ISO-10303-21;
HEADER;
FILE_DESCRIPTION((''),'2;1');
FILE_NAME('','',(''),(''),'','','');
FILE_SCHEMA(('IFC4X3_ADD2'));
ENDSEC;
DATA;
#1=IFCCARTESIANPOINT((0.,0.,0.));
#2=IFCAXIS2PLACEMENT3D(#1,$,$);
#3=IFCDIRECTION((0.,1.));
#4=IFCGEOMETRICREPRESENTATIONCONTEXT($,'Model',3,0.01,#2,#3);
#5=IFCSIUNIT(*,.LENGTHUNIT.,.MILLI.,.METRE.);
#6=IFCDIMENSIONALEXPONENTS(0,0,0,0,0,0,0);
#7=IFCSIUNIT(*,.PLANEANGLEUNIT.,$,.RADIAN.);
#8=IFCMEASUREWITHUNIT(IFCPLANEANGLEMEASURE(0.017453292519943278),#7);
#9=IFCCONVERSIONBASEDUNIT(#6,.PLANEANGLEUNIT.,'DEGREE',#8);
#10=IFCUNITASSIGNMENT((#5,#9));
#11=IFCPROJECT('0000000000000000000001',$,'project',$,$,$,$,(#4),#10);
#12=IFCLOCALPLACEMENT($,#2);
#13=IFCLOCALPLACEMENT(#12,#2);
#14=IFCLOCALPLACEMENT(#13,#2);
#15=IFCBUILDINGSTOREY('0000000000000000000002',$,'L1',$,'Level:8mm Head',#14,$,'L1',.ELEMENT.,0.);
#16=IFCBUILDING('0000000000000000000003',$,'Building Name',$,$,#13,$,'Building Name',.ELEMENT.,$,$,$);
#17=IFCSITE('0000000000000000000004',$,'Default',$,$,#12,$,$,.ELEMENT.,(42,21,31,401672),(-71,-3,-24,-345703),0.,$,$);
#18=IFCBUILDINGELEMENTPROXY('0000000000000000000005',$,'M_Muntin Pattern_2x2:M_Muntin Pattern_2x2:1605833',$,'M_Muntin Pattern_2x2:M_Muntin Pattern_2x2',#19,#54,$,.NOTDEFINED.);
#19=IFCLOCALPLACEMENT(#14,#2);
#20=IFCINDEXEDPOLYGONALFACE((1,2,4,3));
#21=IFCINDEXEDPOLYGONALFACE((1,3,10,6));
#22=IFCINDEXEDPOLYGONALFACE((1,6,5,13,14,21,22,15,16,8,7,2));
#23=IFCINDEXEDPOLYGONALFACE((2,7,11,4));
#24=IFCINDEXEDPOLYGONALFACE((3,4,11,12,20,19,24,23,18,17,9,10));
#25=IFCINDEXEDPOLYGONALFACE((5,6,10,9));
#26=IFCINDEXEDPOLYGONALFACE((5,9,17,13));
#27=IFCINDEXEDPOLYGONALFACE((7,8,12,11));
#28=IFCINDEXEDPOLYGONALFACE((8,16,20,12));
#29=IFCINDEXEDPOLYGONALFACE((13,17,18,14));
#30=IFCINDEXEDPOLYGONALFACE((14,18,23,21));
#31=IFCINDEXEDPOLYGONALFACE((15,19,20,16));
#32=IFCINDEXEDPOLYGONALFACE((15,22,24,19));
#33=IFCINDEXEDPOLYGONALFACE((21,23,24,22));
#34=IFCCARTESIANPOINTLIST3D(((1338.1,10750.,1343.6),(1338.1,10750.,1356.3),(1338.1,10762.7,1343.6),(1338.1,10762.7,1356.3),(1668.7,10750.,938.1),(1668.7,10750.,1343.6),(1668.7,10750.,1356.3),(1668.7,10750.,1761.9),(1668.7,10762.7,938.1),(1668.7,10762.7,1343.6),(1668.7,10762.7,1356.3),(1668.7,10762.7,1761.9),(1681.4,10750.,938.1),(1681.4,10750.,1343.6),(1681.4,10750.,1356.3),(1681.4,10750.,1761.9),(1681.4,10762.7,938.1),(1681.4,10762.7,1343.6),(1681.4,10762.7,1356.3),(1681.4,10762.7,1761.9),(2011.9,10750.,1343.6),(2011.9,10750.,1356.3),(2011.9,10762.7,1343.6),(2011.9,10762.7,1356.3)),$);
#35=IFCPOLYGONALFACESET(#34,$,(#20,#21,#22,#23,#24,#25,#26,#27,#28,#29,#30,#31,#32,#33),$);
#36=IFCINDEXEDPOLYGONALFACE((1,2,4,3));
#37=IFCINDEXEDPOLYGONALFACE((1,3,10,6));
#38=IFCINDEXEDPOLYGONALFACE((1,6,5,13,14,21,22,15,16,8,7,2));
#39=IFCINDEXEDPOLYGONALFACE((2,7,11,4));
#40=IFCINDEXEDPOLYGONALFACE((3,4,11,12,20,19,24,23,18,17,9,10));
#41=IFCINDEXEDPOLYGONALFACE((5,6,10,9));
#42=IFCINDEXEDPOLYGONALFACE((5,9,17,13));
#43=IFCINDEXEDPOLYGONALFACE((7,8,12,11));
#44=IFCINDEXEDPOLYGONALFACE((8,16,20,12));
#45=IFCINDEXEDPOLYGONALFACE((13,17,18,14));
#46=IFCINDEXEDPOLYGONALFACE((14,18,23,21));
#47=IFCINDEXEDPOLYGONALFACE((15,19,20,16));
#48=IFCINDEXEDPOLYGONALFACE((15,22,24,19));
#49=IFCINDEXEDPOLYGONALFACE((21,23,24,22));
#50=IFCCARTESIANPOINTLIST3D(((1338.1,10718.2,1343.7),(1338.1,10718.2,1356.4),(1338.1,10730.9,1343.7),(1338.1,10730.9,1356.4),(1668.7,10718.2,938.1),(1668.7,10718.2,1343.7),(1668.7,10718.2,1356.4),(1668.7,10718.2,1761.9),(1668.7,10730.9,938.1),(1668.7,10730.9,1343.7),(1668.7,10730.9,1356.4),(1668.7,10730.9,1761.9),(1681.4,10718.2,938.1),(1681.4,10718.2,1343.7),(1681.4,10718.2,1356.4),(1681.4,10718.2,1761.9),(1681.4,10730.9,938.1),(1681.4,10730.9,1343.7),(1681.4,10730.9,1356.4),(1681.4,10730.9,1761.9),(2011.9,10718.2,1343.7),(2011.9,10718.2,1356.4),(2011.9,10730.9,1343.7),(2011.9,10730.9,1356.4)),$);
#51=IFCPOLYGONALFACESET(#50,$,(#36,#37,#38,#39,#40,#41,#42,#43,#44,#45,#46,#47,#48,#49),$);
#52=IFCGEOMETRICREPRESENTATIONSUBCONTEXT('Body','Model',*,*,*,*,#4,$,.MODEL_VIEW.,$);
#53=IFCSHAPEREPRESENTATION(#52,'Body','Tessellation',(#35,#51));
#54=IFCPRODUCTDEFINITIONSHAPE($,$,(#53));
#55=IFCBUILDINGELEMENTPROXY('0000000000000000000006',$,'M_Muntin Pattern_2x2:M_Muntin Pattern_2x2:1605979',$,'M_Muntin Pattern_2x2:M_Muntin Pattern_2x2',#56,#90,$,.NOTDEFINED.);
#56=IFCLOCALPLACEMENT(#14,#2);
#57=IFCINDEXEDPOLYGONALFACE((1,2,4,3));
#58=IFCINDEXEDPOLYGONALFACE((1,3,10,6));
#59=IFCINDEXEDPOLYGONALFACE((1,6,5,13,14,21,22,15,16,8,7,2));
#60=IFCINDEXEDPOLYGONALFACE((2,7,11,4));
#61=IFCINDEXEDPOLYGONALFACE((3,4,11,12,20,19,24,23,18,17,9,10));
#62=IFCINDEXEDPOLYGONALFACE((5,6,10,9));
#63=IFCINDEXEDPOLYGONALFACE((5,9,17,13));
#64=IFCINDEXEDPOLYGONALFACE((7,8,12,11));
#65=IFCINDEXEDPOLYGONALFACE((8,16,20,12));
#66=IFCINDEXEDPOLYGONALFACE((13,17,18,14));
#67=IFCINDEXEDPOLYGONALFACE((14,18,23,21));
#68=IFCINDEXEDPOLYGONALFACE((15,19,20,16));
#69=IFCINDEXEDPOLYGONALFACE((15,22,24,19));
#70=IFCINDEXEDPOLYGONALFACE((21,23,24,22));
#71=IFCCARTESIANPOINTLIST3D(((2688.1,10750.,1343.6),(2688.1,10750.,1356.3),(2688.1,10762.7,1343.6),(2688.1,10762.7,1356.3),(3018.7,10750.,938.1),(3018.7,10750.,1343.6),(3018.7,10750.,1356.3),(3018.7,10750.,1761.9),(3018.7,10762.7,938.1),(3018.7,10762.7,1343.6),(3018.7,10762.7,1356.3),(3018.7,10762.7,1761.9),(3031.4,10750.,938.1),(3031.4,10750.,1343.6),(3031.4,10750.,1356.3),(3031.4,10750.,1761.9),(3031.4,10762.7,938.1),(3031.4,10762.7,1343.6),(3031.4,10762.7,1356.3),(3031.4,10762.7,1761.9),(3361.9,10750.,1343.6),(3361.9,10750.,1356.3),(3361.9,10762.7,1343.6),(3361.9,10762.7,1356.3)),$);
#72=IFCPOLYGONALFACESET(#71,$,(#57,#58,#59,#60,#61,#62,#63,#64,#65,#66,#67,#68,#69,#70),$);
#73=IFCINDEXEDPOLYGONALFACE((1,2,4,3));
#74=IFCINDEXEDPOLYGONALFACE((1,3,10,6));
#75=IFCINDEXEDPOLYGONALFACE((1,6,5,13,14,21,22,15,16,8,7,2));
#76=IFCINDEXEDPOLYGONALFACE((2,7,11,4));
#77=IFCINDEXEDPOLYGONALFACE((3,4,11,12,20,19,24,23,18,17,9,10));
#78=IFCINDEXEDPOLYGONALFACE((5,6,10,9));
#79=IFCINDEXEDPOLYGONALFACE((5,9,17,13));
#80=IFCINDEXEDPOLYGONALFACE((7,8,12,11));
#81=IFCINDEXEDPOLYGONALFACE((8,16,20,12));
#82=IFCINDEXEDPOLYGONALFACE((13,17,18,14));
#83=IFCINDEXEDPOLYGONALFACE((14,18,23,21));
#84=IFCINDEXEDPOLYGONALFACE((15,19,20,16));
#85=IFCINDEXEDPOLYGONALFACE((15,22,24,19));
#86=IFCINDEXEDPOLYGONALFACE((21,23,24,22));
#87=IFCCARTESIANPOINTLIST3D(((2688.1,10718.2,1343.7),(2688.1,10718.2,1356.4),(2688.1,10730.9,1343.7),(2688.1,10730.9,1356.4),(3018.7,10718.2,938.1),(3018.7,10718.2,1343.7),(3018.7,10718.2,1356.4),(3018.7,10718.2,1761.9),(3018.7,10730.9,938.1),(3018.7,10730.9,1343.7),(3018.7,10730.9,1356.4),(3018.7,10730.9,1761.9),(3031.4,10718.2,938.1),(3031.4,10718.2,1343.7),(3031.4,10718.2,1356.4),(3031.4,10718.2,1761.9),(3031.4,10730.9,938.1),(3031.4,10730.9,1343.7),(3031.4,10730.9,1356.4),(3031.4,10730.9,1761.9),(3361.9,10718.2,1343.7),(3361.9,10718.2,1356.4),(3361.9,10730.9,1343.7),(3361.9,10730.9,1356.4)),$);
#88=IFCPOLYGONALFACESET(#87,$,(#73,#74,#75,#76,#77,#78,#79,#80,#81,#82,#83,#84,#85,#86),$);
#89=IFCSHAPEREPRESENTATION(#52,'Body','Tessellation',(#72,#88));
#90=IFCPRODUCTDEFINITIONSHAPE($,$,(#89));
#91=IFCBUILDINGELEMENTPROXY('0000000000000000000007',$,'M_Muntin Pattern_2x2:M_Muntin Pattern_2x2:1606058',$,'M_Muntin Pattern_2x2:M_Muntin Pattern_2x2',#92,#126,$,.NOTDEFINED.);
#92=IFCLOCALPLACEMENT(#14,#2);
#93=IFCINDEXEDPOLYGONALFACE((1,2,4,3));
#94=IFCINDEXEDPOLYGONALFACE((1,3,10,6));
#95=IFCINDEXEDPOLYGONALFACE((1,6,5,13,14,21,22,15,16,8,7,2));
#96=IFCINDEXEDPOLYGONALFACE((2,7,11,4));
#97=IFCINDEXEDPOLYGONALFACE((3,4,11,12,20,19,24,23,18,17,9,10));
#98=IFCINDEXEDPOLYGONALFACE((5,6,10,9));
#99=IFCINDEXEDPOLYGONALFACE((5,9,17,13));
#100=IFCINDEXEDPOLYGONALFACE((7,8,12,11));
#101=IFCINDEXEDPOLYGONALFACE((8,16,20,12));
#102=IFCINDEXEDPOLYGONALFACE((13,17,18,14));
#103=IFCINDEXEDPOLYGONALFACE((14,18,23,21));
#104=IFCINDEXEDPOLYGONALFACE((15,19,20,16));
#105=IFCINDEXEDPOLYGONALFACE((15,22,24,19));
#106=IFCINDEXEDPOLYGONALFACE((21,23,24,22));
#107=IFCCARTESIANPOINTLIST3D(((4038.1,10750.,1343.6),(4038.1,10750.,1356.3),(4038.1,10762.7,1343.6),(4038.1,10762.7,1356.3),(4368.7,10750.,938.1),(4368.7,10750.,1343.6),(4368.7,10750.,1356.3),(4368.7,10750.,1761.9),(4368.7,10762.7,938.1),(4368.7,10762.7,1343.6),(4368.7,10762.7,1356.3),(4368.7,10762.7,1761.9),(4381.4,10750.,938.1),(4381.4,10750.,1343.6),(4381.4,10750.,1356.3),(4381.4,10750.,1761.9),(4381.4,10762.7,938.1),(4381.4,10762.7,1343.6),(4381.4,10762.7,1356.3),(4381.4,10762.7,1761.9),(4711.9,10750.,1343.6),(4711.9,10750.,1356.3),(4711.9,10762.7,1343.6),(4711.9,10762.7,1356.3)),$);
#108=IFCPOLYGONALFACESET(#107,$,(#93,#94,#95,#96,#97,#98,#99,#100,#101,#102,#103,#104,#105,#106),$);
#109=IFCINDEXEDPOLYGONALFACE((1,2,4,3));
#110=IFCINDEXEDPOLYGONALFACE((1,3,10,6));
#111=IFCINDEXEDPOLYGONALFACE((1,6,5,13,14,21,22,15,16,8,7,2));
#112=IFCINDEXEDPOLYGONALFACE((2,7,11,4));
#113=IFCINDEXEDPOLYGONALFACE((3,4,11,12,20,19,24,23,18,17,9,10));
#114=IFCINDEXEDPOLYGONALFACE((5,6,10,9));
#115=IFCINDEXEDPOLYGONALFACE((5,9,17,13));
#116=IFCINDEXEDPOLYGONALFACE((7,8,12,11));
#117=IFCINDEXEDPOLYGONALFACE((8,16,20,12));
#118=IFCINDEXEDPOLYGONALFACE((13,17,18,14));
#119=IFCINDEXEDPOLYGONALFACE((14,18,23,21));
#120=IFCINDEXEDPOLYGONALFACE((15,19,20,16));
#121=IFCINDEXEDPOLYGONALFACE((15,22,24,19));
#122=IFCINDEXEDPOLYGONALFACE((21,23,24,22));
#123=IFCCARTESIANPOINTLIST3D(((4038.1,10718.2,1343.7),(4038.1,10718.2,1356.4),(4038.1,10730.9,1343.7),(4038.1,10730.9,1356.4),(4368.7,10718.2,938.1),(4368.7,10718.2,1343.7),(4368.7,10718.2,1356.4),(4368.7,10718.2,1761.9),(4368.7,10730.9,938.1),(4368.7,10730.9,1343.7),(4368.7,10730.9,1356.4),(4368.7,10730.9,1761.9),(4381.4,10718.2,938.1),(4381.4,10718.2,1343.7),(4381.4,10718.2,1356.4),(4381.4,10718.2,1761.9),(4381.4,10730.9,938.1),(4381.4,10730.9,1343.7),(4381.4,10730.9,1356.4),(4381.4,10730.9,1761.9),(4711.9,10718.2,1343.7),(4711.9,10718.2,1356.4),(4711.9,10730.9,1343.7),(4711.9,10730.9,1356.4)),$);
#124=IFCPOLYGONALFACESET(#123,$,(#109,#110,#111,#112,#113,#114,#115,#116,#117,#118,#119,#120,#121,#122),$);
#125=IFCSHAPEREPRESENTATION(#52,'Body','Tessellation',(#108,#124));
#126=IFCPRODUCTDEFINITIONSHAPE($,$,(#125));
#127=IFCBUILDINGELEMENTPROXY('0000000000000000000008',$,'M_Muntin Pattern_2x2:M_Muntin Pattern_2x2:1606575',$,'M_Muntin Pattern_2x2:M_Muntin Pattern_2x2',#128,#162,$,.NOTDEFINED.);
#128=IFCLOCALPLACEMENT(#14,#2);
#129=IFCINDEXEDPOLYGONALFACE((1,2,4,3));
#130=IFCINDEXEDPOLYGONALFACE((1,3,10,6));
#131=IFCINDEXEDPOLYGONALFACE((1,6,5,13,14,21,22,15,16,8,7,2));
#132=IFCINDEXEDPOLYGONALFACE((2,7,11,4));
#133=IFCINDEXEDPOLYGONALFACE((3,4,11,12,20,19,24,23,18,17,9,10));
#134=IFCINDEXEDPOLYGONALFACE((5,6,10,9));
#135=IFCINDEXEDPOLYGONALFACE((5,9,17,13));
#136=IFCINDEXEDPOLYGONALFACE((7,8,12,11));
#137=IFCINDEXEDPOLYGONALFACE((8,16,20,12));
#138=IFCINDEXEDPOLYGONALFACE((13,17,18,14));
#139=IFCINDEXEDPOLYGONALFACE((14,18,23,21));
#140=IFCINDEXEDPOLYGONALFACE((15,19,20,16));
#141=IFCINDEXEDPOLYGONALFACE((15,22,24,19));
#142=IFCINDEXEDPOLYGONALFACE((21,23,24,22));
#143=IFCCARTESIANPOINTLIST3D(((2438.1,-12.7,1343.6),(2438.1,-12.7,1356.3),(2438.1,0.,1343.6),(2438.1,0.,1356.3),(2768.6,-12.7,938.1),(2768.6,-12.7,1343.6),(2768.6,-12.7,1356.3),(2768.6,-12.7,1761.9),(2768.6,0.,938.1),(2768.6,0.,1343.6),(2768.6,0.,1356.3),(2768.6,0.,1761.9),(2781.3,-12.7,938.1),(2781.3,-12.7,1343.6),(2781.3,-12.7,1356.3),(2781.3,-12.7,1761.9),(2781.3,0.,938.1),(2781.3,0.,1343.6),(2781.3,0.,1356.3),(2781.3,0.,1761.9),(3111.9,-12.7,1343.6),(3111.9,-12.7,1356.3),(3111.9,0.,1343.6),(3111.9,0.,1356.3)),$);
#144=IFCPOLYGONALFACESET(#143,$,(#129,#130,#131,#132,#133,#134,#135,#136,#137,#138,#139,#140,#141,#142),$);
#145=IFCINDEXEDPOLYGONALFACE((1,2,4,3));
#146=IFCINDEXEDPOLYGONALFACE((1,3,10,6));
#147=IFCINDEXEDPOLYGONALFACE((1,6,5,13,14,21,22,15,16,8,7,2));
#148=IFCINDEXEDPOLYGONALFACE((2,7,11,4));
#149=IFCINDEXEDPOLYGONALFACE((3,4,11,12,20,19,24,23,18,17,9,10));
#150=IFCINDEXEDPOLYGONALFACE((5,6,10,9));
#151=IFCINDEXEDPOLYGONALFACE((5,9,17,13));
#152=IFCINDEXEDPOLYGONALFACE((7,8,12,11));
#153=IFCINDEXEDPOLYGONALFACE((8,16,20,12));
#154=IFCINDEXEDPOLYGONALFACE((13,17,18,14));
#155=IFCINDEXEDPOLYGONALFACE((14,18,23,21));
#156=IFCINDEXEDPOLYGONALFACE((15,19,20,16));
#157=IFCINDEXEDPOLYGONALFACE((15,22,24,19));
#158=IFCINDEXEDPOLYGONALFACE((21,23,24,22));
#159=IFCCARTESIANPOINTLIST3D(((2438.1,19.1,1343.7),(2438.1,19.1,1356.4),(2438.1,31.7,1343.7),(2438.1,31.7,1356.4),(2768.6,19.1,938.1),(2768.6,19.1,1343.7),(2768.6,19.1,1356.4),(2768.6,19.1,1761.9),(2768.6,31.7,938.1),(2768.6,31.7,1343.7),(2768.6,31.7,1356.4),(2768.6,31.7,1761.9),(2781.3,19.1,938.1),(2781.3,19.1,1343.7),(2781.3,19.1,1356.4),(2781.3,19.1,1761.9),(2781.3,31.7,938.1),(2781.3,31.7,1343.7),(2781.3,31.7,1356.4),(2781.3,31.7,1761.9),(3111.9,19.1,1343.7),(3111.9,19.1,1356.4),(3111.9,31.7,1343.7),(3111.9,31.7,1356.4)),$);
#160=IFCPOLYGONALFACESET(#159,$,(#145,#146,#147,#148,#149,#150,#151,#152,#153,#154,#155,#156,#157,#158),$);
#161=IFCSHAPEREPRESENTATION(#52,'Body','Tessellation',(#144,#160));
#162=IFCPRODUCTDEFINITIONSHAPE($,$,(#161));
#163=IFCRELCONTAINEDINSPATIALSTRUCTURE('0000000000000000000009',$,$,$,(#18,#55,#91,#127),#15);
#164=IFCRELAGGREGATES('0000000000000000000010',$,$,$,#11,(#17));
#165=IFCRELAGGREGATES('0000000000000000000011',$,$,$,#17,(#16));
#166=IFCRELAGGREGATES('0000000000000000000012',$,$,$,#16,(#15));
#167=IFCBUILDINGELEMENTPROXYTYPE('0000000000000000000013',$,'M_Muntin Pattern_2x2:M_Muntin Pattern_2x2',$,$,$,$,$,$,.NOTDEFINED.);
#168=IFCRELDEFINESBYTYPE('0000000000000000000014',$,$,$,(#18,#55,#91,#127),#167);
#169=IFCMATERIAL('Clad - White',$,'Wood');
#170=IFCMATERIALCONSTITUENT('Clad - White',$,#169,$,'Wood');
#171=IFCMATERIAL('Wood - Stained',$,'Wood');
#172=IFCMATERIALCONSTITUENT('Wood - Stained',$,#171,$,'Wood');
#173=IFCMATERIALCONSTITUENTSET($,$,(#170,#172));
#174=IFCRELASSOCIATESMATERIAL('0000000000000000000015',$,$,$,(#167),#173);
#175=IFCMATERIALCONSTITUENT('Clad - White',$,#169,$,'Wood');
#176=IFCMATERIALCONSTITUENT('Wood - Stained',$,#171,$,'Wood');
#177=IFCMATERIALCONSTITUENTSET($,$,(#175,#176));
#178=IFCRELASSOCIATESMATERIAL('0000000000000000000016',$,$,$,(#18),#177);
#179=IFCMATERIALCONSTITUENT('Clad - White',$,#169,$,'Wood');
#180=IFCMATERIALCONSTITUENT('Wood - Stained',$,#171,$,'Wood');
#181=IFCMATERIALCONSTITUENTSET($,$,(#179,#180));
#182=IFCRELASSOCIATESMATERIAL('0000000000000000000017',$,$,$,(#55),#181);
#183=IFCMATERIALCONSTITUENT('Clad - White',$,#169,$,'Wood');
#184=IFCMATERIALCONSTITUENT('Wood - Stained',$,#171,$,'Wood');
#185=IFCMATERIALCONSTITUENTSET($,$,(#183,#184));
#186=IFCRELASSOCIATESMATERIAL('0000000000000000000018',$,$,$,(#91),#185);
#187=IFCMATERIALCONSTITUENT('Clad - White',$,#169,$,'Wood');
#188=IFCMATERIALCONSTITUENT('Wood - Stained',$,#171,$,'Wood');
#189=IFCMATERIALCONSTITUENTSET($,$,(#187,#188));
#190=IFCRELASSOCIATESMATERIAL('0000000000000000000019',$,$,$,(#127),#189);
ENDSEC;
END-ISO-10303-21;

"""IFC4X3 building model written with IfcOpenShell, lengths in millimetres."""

from ifc_helpers import new_model, entity, si_unit, converted_unit, direction, frame, origin, place, context, subcontext, project, spatial, polyline, outline, extrude, source, transform, mapped, material, constituent, constituent_set, type_object, type_shapes, element, save


model = new_model("IFC4X3")

# Units and contexts
model_context = context("Model", 3, precision=0.01, world=origin(), true_north=direction((0.0, 1.0)))
body_context = subcontext(model_context, "Body", "Model", "MODEL_VIEW")
ifc_project = project(units=[si_unit("LENGTHUNIT", "METRE", prefix="MILLI"), converted_unit("PLANEANGLEUNIT", "DEGREE", entity("IfcPlaneAngleMeasure", 0.017453292519943278), si_unit("PLANEANGLEUNIT", "RADIAN"), dimensions=[0, 0, 0, 0, 0, 0, 0])], contexts=[model_context])

# Site, building, storey
site_placement = place(None, origin())
site = spatial("IfcSite", under=ifc_project, at=site_placement, Name="Default", CompositionType="ELEMENT", RefLatitude=(42, 21, 31, 401672), RefLongitude=(-71, -3, -24, -345703), RefElevation=0.0)
building_placement = place(site_placement, origin())
building = spatial("IfcBuilding", under=site, at=building_placement, Name="Building Name", LongName="Building Name", CompositionType="ELEMENT")
storey_placement = place(building_placement, origin())
storey = spatial("IfcBuildingStorey", under=building, at=storey_placement, Name="L1", ObjectType="Level:8mm Head", LongName="L1", CompositionType="ELEMENT", Elevation=0.0)

# Building element proxies
ifc_material_1 = material(Name="Clad - White", Category="Wood")
ifc_constituent_1 = constituent(ifc_material_1, Name="Clad - White", Category="Wood")
ifc_material_2 = material(Name="Wood - Stained", Category="Wood")
ifc_constituent_2 = constituent(ifc_material_2, Name="Wood - Stained", Category="Wood")
ifc_constituent_set_1 = constituent_set(constituents=[ifc_constituent_1, ifc_constituent_2])
ifc_constituent_3 = constituent(ifc_material_1, Name="Clad - White", Category="Wood")
ifc_constituent_4 = constituent(ifc_material_2, Name="Wood - Stained", Category="Wood")
ifc_constituent_set_2 = constituent_set(constituents=[ifc_constituent_3, ifc_constituent_4])
building_element_proxy_type_1 = type_object("IfcBuildingElementProxyType", Name="M_Muntin Pattern_2x2:M_Muntin Pattern_2x2", PredefinedType="NOTDEFINED", material=ifc_constituent_set_2)
shared_shape_1 = source(origin(), body_context, "Body", "SweptSolid", [
    extrude(outline(polyline([(6.4, -6.4), (411.9, -6.4), (411.9, 6.3), (6.4, 6.3), (6.4, 336.9), (-6.3, 336.9), (-6.3, 6.3), (-411.9, 6.3), (-411.9, -6.4), (-6.3, -6.4), (-6.3, -336.9), (6.4, -336.9), (6.4, -6.4)])), frame((0.0, -22.2, 411.9), z_axis=(0.0, 1.0, 0.0), x_axis=(0.0, 0.0, 1.0)), (0.0, 0.0, 1.0), 12.7),
    extrude(outline(polyline([(6.4, -6.4), (411.9, -6.4), (411.9, 6.3), (6.4, 6.3), (6.4, 336.9), (-6.3, 336.9), (-6.3, 6.3), (-411.9, 6.3), (-411.9, -6.4), (-6.3, -6.4), (-6.3, -336.9), (6.4, -336.9), (6.4, -6.4)])), frame((0.0, 9.5, 411.9), z_axis=(0.0, 1.0, 0.0), x_axis=(0.0, 0.0, 1.0)), (0.0, 0.0, 1.0), 12.7),
])
type_shapes(building_element_proxy_type_1, [shared_shape_1])
proxy_1_placement = place(storey_placement, frame((1675.0, 10740.5, 938.1), z_axis=(0.0, 0.0, 1.0), x_axis=(-1.0, 0.0, 0.0)))
element("IfcBuildingElementProxy", 1, at=proxy_1_placement, inside=storey, type_object=building_element_proxy_type_1, material=ifc_constituent_set_1, Name="M_Muntin Pattern_2x2:M_Muntin Pattern_2x2:1605833", ObjectType="M_Muntin Pattern_2x2:M_Muntin Pattern_2x2", PredefinedType="NOTDEFINED", context=body_context, shape_type="MappedRepresentation", body=[
    mapped(shared_shape_1, transform((0.0, 0.0, 0.0), scale=1.0)),
])
ifc_constituent_5 = constituent(ifc_material_1, Name="Clad - White", Category="Wood")
ifc_constituent_6 = constituent(ifc_material_2, Name="Wood - Stained", Category="Wood")
ifc_constituent_set_3 = constituent_set(constituents=[ifc_constituent_5, ifc_constituent_6])
proxy_2_placement = place(storey_placement, frame((3025.0, 10740.5, 938.1), z_axis=(0.0, 0.0, 1.0), x_axis=(-1.0, 0.0, 0.0)))
element("IfcBuildingElementProxy", 2, at=proxy_2_placement, inside=storey, type_object=building_element_proxy_type_1, material=ifc_constituent_set_3, Name="M_Muntin Pattern_2x2:M_Muntin Pattern_2x2:1605979", ObjectType="M_Muntin Pattern_2x2:M_Muntin Pattern_2x2", PredefinedType="NOTDEFINED", context=body_context, shape_type="MappedRepresentation", body=[
    mapped(shared_shape_1, transform((0.0, 0.0, 0.0), scale=1.0)),
])
ifc_constituent_7 = constituent(ifc_material_1, Name="Clad - White", Category="Wood")
ifc_constituent_8 = constituent(ifc_material_2, Name="Wood - Stained", Category="Wood")
ifc_constituent_set_4 = constituent_set(constituents=[ifc_constituent_7, ifc_constituent_8])
proxy_3_placement = place(storey_placement, frame((4375.0, 10740.5, 938.1), z_axis=(0.0, 0.0, 1.0), x_axis=(-1.0, 0.0, 0.0)))
element("IfcBuildingElementProxy", 3, at=proxy_3_placement, inside=storey, type_object=building_element_proxy_type_1, material=ifc_constituent_set_4, Name="M_Muntin Pattern_2x2:M_Muntin Pattern_2x2:1606058", ObjectType="M_Muntin Pattern_2x2:M_Muntin Pattern_2x2", PredefinedType="NOTDEFINED", context=body_context, shape_type="MappedRepresentation", body=[
    mapped(shared_shape_1, transform((0.0, 0.0, 0.0), scale=1.0)),
])
ifc_constituent_9 = constituent(ifc_material_1, Name="Clad - White", Category="Wood")
ifc_constituent_10 = constituent(ifc_material_2, Name="Wood - Stained", Category="Wood")
ifc_constituent_set_5 = constituent_set(constituents=[ifc_constituent_9, ifc_constituent_10])
proxy_4_placement = place(storey_placement, frame((2775.0, 9.5, 938.1)))
element("IfcBuildingElementProxy", 4, at=proxy_4_placement, inside=storey, type_object=building_element_proxy_type_1, material=ifc_constituent_set_5, Name="M_Muntin Pattern_2x2:M_Muntin Pattern_2x2:1606575", ObjectType="M_Muntin Pattern_2x2:M_Muntin Pattern_2x2", PredefinedType="NOTDEFINED", context=body_context, shape_type="MappedRepresentation", body=[
    mapped(shared_shape_1, transform((0.0, 0.0, 0.0), scale=1.0)),
])

save(model, "model.ifc")
